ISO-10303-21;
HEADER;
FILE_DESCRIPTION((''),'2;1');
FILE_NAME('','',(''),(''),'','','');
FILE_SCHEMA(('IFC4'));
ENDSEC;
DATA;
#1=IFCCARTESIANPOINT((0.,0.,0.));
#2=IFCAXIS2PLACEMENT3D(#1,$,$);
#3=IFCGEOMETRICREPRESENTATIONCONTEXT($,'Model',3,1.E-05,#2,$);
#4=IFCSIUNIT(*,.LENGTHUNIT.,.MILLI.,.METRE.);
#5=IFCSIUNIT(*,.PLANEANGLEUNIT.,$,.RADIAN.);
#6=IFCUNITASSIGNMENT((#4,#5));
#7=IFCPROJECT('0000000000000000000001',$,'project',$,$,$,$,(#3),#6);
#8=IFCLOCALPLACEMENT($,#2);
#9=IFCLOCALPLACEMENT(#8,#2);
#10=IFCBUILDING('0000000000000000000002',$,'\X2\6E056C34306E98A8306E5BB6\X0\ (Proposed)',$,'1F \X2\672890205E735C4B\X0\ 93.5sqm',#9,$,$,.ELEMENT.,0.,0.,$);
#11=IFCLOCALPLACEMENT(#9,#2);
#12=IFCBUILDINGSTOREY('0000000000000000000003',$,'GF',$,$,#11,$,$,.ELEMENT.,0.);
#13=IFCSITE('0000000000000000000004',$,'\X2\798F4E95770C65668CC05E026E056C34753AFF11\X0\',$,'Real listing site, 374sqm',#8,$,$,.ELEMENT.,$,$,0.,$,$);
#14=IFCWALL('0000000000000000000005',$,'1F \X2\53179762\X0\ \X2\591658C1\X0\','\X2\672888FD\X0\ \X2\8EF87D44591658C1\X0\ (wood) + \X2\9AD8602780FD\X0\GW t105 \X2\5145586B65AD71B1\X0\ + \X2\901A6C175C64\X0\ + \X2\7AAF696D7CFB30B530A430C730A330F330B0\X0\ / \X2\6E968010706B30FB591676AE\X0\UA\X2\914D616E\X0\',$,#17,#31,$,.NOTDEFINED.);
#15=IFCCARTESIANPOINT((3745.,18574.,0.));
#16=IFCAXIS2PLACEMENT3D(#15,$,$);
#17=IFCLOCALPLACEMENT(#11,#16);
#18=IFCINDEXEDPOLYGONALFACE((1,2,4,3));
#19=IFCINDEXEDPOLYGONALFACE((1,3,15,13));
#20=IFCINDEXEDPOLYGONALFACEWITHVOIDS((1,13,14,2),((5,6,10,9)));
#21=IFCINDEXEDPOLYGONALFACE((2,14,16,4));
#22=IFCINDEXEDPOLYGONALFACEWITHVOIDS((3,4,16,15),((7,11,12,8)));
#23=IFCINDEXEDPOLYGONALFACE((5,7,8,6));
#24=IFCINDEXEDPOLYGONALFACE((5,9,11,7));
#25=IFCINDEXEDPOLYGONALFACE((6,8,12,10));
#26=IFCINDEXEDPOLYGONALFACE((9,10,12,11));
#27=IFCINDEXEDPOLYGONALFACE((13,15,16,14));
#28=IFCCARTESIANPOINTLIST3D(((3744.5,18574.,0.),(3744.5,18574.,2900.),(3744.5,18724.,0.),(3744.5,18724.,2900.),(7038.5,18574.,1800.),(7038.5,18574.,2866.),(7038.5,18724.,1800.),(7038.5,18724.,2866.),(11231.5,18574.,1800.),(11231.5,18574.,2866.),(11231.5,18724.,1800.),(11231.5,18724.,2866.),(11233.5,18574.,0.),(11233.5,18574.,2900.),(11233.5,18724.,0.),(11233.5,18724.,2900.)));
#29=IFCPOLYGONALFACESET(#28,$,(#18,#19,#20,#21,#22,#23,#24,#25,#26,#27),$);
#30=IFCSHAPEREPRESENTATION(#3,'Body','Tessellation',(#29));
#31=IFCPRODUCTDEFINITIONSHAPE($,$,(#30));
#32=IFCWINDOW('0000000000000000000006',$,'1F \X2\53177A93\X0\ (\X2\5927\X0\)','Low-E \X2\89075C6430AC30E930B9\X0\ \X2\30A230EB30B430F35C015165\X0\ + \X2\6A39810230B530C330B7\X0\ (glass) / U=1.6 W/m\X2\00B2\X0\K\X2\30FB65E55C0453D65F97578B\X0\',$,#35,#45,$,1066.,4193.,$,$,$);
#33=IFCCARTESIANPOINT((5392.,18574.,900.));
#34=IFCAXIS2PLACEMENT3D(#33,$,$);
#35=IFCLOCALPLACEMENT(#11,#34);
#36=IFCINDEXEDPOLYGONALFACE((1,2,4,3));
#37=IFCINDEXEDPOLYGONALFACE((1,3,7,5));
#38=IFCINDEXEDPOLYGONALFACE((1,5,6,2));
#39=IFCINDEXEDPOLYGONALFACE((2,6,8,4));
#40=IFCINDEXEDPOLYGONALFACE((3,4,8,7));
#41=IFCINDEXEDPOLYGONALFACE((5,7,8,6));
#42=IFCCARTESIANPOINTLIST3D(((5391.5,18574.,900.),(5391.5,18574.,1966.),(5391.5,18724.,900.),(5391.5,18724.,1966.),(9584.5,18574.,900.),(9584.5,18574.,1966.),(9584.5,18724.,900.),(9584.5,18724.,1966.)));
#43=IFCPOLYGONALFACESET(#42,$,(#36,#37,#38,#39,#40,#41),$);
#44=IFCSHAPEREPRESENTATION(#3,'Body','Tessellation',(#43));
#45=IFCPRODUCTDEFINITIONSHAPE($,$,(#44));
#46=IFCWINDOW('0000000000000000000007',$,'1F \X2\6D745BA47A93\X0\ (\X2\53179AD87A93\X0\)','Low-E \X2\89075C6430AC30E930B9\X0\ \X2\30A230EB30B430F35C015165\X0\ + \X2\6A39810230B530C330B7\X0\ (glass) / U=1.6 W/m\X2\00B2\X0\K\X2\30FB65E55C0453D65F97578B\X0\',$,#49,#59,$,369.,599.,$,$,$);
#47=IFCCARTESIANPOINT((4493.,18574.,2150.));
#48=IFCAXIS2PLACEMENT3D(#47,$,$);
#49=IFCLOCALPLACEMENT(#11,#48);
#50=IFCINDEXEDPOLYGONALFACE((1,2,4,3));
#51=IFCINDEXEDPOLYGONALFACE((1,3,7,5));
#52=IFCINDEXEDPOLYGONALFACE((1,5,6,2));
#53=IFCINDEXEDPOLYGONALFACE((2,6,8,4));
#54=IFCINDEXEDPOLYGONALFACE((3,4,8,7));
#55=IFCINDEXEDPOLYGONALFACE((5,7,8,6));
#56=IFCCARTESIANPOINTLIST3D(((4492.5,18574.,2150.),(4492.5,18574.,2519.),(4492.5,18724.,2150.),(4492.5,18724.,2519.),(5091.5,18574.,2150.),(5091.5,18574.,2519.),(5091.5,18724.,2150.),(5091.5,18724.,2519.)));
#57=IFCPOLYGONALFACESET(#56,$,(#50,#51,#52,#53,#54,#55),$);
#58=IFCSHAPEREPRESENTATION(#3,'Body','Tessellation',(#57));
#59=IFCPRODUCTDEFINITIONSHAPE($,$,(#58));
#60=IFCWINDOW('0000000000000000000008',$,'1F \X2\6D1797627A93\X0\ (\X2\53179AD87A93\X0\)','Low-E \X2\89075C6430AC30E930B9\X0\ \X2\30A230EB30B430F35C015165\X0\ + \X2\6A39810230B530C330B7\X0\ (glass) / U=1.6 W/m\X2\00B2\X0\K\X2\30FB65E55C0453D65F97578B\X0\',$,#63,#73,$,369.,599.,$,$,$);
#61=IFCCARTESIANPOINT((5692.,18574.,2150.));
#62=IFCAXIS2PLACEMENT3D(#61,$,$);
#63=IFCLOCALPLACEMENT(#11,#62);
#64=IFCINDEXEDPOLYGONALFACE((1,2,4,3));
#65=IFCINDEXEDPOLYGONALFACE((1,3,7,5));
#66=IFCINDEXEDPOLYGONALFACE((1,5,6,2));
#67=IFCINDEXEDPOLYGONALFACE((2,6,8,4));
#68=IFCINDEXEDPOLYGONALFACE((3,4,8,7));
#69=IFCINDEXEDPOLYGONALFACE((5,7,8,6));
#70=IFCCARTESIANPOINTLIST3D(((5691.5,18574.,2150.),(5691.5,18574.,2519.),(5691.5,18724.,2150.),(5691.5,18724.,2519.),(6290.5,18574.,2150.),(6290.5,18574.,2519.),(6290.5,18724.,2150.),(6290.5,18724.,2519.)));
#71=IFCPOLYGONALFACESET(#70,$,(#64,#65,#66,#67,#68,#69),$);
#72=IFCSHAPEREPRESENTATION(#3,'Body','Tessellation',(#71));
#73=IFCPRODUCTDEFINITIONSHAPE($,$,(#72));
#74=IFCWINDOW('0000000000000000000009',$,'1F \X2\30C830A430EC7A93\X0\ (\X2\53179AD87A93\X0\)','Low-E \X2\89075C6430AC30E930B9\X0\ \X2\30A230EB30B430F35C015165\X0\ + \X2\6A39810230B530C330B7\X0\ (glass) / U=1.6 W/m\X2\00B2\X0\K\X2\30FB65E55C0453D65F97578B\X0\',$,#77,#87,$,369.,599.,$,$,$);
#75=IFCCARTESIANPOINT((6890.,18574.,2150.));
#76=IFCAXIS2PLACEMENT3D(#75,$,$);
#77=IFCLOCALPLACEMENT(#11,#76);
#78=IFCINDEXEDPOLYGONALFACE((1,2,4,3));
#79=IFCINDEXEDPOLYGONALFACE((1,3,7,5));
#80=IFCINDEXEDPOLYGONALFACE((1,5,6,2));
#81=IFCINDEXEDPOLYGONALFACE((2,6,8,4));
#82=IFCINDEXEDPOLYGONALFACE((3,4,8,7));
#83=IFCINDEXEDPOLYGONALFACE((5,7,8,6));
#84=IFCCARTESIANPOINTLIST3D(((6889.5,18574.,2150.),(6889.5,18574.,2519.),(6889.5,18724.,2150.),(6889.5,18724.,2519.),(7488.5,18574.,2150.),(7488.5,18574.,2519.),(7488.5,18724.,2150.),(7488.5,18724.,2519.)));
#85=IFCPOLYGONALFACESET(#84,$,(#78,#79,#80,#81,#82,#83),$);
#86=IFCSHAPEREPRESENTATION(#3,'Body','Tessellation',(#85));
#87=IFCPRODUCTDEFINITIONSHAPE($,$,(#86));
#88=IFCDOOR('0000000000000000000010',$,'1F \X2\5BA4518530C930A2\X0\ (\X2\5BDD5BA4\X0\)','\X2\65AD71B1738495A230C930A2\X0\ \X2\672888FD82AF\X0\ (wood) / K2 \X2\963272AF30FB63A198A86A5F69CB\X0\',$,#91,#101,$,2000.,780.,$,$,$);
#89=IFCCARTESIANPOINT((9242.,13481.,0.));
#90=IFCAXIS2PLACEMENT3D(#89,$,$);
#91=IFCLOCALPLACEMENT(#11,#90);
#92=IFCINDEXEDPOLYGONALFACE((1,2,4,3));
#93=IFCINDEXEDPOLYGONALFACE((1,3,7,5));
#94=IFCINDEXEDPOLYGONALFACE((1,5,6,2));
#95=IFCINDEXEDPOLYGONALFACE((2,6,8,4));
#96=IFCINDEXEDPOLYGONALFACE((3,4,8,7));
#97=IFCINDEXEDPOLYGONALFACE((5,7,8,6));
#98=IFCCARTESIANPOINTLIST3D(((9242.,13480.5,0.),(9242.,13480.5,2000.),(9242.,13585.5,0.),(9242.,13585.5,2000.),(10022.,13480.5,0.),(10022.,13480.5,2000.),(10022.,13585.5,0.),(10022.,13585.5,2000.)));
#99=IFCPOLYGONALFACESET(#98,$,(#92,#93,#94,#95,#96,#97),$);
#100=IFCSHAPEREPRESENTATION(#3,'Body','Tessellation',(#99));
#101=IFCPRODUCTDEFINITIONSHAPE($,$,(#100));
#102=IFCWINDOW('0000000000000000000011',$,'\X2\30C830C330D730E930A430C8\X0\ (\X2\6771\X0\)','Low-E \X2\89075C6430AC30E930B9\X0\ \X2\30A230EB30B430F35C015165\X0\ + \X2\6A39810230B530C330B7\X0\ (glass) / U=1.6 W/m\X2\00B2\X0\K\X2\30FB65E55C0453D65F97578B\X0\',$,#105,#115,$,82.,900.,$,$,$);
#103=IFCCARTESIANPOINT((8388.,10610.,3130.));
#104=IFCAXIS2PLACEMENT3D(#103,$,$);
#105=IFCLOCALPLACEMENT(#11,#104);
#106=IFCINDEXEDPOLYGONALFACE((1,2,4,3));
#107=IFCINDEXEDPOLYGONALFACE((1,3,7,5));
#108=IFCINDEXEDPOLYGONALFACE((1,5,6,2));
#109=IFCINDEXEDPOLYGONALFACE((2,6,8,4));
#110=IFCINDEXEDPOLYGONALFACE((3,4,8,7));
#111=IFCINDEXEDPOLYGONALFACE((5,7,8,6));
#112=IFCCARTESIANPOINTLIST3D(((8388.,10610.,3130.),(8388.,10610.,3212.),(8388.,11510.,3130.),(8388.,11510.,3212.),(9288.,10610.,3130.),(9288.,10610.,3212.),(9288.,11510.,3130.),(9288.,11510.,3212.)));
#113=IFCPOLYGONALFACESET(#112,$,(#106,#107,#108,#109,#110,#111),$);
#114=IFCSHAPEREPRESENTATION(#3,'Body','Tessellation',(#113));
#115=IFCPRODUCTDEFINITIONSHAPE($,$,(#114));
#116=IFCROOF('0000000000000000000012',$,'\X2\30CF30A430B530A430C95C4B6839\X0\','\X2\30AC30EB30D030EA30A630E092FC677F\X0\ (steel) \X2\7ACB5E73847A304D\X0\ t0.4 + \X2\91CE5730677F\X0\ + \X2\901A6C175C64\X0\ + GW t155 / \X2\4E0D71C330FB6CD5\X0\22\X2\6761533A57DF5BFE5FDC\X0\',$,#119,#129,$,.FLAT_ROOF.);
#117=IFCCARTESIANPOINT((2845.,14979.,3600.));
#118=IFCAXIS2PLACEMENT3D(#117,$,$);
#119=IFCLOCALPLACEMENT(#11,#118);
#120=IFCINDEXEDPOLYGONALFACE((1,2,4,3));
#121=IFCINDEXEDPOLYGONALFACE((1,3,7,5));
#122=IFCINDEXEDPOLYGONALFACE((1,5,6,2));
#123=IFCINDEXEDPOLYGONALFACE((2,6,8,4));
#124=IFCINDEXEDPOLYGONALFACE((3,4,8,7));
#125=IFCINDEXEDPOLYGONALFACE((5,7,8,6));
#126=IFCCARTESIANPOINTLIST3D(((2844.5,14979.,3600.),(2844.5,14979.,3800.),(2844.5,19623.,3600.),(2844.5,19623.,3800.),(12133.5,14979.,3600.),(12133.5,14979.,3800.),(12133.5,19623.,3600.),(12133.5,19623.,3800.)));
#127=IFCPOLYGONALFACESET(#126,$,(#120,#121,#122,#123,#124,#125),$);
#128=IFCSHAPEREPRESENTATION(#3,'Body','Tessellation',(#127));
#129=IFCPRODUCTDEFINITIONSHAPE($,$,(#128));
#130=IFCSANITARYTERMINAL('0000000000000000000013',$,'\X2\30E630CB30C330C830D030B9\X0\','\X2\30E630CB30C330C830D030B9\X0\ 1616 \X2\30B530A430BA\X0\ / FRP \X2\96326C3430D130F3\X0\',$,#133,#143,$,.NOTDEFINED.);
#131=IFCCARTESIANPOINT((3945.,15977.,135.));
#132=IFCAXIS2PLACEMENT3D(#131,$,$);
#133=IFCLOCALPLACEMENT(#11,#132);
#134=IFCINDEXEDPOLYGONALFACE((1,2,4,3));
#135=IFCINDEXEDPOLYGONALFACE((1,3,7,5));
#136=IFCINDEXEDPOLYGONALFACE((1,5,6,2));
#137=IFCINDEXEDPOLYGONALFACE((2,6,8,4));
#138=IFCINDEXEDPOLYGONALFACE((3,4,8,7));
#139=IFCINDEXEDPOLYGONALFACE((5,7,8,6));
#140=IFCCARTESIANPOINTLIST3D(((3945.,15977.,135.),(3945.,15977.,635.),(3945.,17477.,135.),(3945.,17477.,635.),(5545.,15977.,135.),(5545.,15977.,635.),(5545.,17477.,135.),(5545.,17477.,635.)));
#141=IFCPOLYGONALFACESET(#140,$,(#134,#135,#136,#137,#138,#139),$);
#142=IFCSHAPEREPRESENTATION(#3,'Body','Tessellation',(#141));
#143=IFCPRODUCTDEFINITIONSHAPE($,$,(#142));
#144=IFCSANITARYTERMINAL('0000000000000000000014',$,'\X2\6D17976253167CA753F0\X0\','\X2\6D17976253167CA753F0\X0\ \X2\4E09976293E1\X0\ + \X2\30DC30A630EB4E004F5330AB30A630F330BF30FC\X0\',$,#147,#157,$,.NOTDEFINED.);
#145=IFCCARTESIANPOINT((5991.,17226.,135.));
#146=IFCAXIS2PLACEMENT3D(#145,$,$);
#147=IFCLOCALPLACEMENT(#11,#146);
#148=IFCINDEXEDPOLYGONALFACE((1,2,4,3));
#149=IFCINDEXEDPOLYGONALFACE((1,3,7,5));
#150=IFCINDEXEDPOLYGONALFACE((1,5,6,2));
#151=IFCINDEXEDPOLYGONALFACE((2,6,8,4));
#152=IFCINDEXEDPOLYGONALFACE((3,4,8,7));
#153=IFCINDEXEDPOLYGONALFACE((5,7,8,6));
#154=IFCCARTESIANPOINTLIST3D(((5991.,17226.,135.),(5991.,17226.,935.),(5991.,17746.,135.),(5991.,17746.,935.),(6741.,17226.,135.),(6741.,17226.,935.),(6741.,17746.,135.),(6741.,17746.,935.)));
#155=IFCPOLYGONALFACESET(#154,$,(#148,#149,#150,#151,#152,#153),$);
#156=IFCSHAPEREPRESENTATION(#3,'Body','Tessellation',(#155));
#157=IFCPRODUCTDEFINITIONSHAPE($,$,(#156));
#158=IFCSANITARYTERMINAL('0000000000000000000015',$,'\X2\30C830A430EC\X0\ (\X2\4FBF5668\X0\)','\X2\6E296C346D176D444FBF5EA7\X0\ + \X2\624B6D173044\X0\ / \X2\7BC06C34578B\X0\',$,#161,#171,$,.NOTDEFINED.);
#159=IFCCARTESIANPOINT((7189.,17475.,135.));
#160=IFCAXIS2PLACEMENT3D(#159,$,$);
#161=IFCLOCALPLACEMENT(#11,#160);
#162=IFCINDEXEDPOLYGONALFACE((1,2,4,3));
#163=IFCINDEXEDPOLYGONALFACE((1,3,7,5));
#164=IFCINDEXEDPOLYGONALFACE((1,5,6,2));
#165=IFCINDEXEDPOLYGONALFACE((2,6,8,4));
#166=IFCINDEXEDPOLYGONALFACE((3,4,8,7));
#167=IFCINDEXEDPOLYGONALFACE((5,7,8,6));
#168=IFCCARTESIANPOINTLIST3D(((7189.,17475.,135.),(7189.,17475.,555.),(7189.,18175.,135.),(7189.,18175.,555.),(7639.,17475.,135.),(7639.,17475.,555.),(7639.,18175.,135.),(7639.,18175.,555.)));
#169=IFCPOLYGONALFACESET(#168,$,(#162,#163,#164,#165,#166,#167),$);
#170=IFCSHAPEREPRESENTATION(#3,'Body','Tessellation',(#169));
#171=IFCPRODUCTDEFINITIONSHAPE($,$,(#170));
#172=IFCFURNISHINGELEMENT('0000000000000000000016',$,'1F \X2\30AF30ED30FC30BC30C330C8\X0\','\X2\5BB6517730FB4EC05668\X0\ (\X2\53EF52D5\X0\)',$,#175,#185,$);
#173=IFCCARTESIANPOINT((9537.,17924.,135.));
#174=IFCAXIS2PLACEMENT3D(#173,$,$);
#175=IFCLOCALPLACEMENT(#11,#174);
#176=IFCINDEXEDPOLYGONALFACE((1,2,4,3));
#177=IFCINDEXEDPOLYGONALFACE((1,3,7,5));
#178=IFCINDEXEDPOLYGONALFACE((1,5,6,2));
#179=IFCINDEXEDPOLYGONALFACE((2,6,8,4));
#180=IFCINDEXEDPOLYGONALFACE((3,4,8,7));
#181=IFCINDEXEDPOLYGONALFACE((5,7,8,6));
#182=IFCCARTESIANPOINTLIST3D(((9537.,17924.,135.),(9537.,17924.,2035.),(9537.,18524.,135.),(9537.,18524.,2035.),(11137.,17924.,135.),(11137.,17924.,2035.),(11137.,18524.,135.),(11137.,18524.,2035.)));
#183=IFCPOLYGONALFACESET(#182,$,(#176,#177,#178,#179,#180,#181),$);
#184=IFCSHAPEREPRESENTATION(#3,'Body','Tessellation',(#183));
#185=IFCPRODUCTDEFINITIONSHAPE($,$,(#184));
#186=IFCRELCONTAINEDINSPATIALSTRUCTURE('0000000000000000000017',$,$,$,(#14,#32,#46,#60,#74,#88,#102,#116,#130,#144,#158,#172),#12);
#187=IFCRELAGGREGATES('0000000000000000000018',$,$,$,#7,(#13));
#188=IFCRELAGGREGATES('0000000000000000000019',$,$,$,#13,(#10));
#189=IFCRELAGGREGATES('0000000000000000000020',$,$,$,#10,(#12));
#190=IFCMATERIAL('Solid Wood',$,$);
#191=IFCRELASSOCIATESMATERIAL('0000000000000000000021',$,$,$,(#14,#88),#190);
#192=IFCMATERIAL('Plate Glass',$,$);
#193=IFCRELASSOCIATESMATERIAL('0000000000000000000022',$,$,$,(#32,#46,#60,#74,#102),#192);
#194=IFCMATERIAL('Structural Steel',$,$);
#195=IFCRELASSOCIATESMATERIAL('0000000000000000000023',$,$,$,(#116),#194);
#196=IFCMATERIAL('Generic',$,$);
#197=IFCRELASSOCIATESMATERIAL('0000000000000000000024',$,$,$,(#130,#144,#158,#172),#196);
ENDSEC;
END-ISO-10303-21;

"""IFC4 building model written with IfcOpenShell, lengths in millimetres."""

from ifc_helpers import new_model, si_unit, frame, frame_2d, origin, place, context, project, spatial, rectangle, extrude, material, element, fill, save


model = new_model("IFC4")

# Units and contexts
model_context = context("Model", 3, precision=1e-05, world=origin())
ifc_project = project(units=[si_unit("LENGTHUNIT", "METRE", prefix="MILLI"), si_unit("PLANEANGLEUNIT", "RADIAN")], contexts=[model_context])

# Site, building, storey
site_placement = place(None, origin())
site = spatial("IfcSite", under=ifc_project, at=site_placement, Name="福井県敦賀市清水町１", ObjectType="Real listing site, 374sqm", CompositionType="ELEMENT", RefElevation=0.0)
building_placement = place(site_placement, origin())
building = spatial("IfcBuilding", under=site, at=building_placement, Name="清水の風の家 (Proposed)", ObjectType="1F 木造平屋 93.5sqm", CompositionType="ELEMENT", ElevationOfRefHeight=0.0, ElevationOfTerrain=0.0)
storey_placement = place(building_placement, origin())
storey = spatial("IfcBuildingStorey", under=building, at=storey_placement, Name="GF", CompositionType="ELEMENT", Elevation=0.0)

# Shared definitions
ifc_material_1 = material(Name="Solid Wood")

# Wall, openings, windows
wall_1_placement = place(storey_placement, frame((3745.0, 18574.0, 0.0)))
wall_1 = element("IfcWall", 1, at=wall_1_placement, inside=storey, material=ifc_material_1, Name="1F 北面 外壁", Description="木製 軸組外壁 (wood) + 高性能GW t105 充填断熱 + 通気層 + 窯業系サイディング / 準耐火・外皮UA配慮", PredefinedType="NOTDEFINED", context=model_context, shape_type="SweptSolid", body=[
    extrude(rectangle(XDim=7489.0, YDim=150.0, at=frame_2d((3744.0, 75.0))), frame((3745.0, 18574.0, 0.0)), (0.0, 0.0, 1.0), 2900.0),
])
opening_1_placement = place(storey_placement, frame((5392.0, 18574.0, 900.0)))
opening_1 = element("IfcOpeningElement", 2, at=opening_1_placement, cuts=wall_1, PredefinedType="NOTDEFINED", context=model_context, shape_type="SweptSolid", body=[
    extrude(rectangle(XDim=4193.0, YDim=150.0, at=frame_2d((2096.0, 75.0))), frame((5392.0, 18574.0, 900.0)), (0.0, 0.0, 1.0), 1066.0),
])
opening_2_placement = place(storey_placement, frame((4493.0, 18574.0, 2150.0)))
opening_2 = element("IfcOpeningElement", 3, at=opening_2_placement, cuts=wall_1, PredefinedType="NOTDEFINED", context=model_context, shape_type="SweptSolid", body=[
    extrude(rectangle(XDim=599.0, YDim=150.0, at=frame_2d((299.0, 75.0))), frame((4493.0, 18574.0, 2150.0)), (0.0, 0.0, 1.0), 369.0),
])
opening_3_placement = place(storey_placement, frame((5692.0, 18574.0, 2150.0)))
opening_3 = element("IfcOpeningElement", 4, at=opening_3_placement, cuts=wall_1, PredefinedType="NOTDEFINED", context=model_context, shape_type="SweptSolid", body=[
    extrude(rectangle(XDim=599.0, YDim=150.0, at=frame_2d((299.0, 75.0))), frame((5692.0, 18574.0, 2150.0)), (0.0, 0.0, 1.0), 369.0),
])
opening_4_placement = place(storey_placement, frame((6890.0, 18574.0, 2150.0)))
opening_4 = element("IfcOpeningElement", 5, at=opening_4_placement, cuts=wall_1, PredefinedType="NOTDEFINED", context=model_context, shape_type="SweptSolid", body=[
    extrude(rectangle(XDim=599.0, YDim=150.0, at=frame_2d((299.0, 75.0))), frame((6890.0, 18574.0, 2150.0)), (0.0, 0.0, 1.0), 369.0),
])
ifc_material_2 = material(Name="Plate Glass")
window_1_placement = place(storey_placement, frame((5392.0, 18574.0, 900.0)))
window_1 = element("IfcWindow", 6, at=window_1_placement, inside=storey, material=ifc_material_2, Name="1F 北窓 (大)", Description="Low-E 複層ガラス アルゴン封入 + 樹脂サッシ (glass) / U=1.6 W/m²K・日射取得型", OverallHeight=1066.0, OverallWidth=4193.0, context=model_context, shape_type="SweptSolid", body=[
    extrude(rectangle(XDim=4193.0, YDim=150.0, at=frame_2d((2096.0, 75.0))), frame((5392.0, 18574.0, 900.0)), (0.0, 0.0, 1.0), 1066.0),
])
fill(opening_1, window_1)
window_2_placement = place(storey_placement, frame((4493.0, 18574.0, 2150.0)))
window_2 = element("IfcWindow", 7, at=window_2_placement, inside=storey, material=ifc_material_2, Name="1F 浴室窓 (北高窓)", Description="Low-E 複層ガラス アルゴン封入 + 樹脂サッシ (glass) / U=1.6 W/m²K・日射取得型", OverallHeight=369.0, OverallWidth=599.0, context=model_context, shape_type="SweptSolid", body=[
    extrude(rectangle(XDim=599.0, YDim=150.0, at=frame_2d((299.0, 75.0))), frame((4493.0, 18574.0, 2150.0)), (0.0, 0.0, 1.0), 369.0),
])
fill(opening_2, window_2)
window_3_placement = place(storey_placement, frame((5692.0, 18574.0, 2150.0)))
window_3 = element("IfcWindow", 8, at=window_3_placement, inside=storey, material=ifc_material_2, Name="1F 洗面窓 (北高窓)", Description="Low-E 複層ガラス アルゴン封入 + 樹脂サッシ (glass) / U=1.6 W/m²K・日射取得型", OverallHeight=369.0, OverallWidth=599.0, context=model_context, shape_type="SweptSolid", body=[
    extrude(rectangle(XDim=599.0, YDim=150.0, at=frame_2d((299.0, 75.0))), frame((5692.0, 18574.0, 2150.0)), (0.0, 0.0, 1.0), 369.0),
])
fill(opening_3, window_3)
window_4_placement = place(storey_placement, frame((6890.0, 18574.0, 2150.0)))
window_4 = element("IfcWindow", 9, at=window_4_placement, inside=storey, material=ifc_material_2, Name="1F トイレ窓 (北高窓)", Description="Low-E 複層ガラス アルゴン封入 + 樹脂サッシ (glass) / U=1.6 W/m²K・日射取得型", OverallHeight=369.0, OverallWidth=599.0, context=model_context, shape_type="SweptSolid", body=[
    extrude(rectangle(XDim=599.0, YDim=150.0, at=frame_2d((299.0, 75.0))), frame((6890.0, 18574.0, 2150.0)), (0.0, 0.0, 1.0), 369.0),
])
fill(opening_4, window_4)

# Door
door_1_placement = place(storey_placement, frame((9242.0, 13481.0, 0.0)))
element("IfcDoor", 10, at=door_1_placement, inside=storey, material=ifc_material_1, Name="1F 室内ドア (寝室)", Description="断熱玄関ドア 木製芯 (wood) / K2 防犯・採風機構", OverallHeight=2000.0, OverallWidth=780.0, context=model_context, shape_type="SweptSolid", body=[
    extrude(rectangle(XDim=780.0, YDim=105.0, at=frame_2d((390.0, 52.0))), frame((9242.0, 13481.0, 0.0)), (0.0, 0.0, 1.0), 2000.0),
])

# Window
window_5_placement = place(storey_placement, frame((8388.0, 10610.0, 3130.0)))
element("IfcWindow", 11, at=window_5_placement, inside=storey, material=ifc_material_2, Name="トップライト (東)", Description="Low-E 複層ガラス アルゴン封入 + 樹脂サッシ (glass) / U=1.6 W/m²K・日射取得型", OverallHeight=82.0, OverallWidth=900.0, context=model_context, shape_type="SweptSolid", body=[
    extrude(rectangle(XDim=900.0, YDim=900.0, at=frame_2d((450.0, 450.0))), frame((8388.0, 10610.0, 3130.0)), (0.0, 0.0, 1.0), 82.0),
])

# Roof
ifc_material_3 = material(Name="Structural Steel")
roof_placement = place(storey_placement, frame((2845.0, 14979.0, 3600.0)))
element("IfcRoof", 12, at=roof_placement, inside=storey, material=ifc_material_3, Name="ハイサイド屋根", Description="ガルバリウム鋼板 (steel) 立平葺き t0.4 + 野地板 + 通気層 + GW t155 / 不燃・法22条区域対応", PredefinedType="FLAT_ROOF", context=model_context, shape_type="SweptSolid", body=[
    extrude(rectangle(XDim=9289.0, YDim=4644.0, at=frame_2d((4644.0, 2322.0))), frame((2845.0, 14979.0, 3600.0)), (0.0, 0.0, 1.0), 200.0),
])

# Sanitary terminals
ifc_material_4 = material(Name="Generic")
sanitary_terminal_1_placement = place(storey_placement, frame((3945.0, 15977.0, 135.0)))
element("IfcSanitaryTerminal", 13, at=sanitary_terminal_1_placement, inside=storey, material=ifc_material_4, Name="ユニットバス", Description="ユニットバス 1616 サイズ / FRP 防水パン", PredefinedType="NOTDEFINED", context=model_context, shape_type="SweptSolid", body=[
    extrude(rectangle(XDim=1600.0, YDim=1500.0, at=frame_2d((800.0, 750.0))), frame((3945.0, 15977.0, 135.0)), (0.0, 0.0, 1.0), 500.0),
])
sanitary_terminal_2_placement = place(storey_placement, frame((5991.0, 17226.0, 135.0)))
element("IfcSanitaryTerminal", 14, at=sanitary_terminal_2_placement, inside=storey, material=ifc_material_4, Name="洗面化粧台", Description="洗面化粧台 三面鏡 + ボウル一体カウンター", PredefinedType="NOTDEFINED", context=model_context, shape_type="SweptSolid", body=[
    extrude(rectangle(XDim=750.0, YDim=520.0, at=frame_2d((375.0, 260.0))), frame((5991.0, 17226.0, 135.0)), (0.0, 0.0, 1.0), 800.0),
])
sanitary_terminal_3_placement = place(storey_placement, frame((7189.0, 17475.0, 135.0)))
element("IfcSanitaryTerminal", 15, at=sanitary_terminal_3_placement, inside=storey, material=ifc_material_4, Name="トイレ (便器)", Description="温水洗浄便座 + 手洗い / 節水型", PredefinedType="NOTDEFINED", context=model_context, shape_type="SweptSolid", body=[
    extrude(rectangle(XDim=450.0, YDim=700.0, at=frame_2d((225.0, 350.0))), frame((7189.0, 17475.0, 135.0)), (0.0, 0.0, 1.0), 420.0),
])

# Furnishing element
furnishing_1_placement = place(storey_placement, frame((9537.0, 17924.0, 135.0)))
element("IfcFurnishingElement", 16, at=furnishing_1_placement, inside=storey, material=ifc_material_4, Name="1F クローゼット", Description="家具・什器 (可動)", context=model_context, shape_type="SweptSolid", body=[
    extrude(rectangle(XDim=1600.0, YDim=600.0, at=frame_2d((800.0, 300.0))), frame((9537.0, 17924.0, 135.0)), (0.0, 0.0, 1.0), 1900.0),
])

save(model, "model.ifc")
